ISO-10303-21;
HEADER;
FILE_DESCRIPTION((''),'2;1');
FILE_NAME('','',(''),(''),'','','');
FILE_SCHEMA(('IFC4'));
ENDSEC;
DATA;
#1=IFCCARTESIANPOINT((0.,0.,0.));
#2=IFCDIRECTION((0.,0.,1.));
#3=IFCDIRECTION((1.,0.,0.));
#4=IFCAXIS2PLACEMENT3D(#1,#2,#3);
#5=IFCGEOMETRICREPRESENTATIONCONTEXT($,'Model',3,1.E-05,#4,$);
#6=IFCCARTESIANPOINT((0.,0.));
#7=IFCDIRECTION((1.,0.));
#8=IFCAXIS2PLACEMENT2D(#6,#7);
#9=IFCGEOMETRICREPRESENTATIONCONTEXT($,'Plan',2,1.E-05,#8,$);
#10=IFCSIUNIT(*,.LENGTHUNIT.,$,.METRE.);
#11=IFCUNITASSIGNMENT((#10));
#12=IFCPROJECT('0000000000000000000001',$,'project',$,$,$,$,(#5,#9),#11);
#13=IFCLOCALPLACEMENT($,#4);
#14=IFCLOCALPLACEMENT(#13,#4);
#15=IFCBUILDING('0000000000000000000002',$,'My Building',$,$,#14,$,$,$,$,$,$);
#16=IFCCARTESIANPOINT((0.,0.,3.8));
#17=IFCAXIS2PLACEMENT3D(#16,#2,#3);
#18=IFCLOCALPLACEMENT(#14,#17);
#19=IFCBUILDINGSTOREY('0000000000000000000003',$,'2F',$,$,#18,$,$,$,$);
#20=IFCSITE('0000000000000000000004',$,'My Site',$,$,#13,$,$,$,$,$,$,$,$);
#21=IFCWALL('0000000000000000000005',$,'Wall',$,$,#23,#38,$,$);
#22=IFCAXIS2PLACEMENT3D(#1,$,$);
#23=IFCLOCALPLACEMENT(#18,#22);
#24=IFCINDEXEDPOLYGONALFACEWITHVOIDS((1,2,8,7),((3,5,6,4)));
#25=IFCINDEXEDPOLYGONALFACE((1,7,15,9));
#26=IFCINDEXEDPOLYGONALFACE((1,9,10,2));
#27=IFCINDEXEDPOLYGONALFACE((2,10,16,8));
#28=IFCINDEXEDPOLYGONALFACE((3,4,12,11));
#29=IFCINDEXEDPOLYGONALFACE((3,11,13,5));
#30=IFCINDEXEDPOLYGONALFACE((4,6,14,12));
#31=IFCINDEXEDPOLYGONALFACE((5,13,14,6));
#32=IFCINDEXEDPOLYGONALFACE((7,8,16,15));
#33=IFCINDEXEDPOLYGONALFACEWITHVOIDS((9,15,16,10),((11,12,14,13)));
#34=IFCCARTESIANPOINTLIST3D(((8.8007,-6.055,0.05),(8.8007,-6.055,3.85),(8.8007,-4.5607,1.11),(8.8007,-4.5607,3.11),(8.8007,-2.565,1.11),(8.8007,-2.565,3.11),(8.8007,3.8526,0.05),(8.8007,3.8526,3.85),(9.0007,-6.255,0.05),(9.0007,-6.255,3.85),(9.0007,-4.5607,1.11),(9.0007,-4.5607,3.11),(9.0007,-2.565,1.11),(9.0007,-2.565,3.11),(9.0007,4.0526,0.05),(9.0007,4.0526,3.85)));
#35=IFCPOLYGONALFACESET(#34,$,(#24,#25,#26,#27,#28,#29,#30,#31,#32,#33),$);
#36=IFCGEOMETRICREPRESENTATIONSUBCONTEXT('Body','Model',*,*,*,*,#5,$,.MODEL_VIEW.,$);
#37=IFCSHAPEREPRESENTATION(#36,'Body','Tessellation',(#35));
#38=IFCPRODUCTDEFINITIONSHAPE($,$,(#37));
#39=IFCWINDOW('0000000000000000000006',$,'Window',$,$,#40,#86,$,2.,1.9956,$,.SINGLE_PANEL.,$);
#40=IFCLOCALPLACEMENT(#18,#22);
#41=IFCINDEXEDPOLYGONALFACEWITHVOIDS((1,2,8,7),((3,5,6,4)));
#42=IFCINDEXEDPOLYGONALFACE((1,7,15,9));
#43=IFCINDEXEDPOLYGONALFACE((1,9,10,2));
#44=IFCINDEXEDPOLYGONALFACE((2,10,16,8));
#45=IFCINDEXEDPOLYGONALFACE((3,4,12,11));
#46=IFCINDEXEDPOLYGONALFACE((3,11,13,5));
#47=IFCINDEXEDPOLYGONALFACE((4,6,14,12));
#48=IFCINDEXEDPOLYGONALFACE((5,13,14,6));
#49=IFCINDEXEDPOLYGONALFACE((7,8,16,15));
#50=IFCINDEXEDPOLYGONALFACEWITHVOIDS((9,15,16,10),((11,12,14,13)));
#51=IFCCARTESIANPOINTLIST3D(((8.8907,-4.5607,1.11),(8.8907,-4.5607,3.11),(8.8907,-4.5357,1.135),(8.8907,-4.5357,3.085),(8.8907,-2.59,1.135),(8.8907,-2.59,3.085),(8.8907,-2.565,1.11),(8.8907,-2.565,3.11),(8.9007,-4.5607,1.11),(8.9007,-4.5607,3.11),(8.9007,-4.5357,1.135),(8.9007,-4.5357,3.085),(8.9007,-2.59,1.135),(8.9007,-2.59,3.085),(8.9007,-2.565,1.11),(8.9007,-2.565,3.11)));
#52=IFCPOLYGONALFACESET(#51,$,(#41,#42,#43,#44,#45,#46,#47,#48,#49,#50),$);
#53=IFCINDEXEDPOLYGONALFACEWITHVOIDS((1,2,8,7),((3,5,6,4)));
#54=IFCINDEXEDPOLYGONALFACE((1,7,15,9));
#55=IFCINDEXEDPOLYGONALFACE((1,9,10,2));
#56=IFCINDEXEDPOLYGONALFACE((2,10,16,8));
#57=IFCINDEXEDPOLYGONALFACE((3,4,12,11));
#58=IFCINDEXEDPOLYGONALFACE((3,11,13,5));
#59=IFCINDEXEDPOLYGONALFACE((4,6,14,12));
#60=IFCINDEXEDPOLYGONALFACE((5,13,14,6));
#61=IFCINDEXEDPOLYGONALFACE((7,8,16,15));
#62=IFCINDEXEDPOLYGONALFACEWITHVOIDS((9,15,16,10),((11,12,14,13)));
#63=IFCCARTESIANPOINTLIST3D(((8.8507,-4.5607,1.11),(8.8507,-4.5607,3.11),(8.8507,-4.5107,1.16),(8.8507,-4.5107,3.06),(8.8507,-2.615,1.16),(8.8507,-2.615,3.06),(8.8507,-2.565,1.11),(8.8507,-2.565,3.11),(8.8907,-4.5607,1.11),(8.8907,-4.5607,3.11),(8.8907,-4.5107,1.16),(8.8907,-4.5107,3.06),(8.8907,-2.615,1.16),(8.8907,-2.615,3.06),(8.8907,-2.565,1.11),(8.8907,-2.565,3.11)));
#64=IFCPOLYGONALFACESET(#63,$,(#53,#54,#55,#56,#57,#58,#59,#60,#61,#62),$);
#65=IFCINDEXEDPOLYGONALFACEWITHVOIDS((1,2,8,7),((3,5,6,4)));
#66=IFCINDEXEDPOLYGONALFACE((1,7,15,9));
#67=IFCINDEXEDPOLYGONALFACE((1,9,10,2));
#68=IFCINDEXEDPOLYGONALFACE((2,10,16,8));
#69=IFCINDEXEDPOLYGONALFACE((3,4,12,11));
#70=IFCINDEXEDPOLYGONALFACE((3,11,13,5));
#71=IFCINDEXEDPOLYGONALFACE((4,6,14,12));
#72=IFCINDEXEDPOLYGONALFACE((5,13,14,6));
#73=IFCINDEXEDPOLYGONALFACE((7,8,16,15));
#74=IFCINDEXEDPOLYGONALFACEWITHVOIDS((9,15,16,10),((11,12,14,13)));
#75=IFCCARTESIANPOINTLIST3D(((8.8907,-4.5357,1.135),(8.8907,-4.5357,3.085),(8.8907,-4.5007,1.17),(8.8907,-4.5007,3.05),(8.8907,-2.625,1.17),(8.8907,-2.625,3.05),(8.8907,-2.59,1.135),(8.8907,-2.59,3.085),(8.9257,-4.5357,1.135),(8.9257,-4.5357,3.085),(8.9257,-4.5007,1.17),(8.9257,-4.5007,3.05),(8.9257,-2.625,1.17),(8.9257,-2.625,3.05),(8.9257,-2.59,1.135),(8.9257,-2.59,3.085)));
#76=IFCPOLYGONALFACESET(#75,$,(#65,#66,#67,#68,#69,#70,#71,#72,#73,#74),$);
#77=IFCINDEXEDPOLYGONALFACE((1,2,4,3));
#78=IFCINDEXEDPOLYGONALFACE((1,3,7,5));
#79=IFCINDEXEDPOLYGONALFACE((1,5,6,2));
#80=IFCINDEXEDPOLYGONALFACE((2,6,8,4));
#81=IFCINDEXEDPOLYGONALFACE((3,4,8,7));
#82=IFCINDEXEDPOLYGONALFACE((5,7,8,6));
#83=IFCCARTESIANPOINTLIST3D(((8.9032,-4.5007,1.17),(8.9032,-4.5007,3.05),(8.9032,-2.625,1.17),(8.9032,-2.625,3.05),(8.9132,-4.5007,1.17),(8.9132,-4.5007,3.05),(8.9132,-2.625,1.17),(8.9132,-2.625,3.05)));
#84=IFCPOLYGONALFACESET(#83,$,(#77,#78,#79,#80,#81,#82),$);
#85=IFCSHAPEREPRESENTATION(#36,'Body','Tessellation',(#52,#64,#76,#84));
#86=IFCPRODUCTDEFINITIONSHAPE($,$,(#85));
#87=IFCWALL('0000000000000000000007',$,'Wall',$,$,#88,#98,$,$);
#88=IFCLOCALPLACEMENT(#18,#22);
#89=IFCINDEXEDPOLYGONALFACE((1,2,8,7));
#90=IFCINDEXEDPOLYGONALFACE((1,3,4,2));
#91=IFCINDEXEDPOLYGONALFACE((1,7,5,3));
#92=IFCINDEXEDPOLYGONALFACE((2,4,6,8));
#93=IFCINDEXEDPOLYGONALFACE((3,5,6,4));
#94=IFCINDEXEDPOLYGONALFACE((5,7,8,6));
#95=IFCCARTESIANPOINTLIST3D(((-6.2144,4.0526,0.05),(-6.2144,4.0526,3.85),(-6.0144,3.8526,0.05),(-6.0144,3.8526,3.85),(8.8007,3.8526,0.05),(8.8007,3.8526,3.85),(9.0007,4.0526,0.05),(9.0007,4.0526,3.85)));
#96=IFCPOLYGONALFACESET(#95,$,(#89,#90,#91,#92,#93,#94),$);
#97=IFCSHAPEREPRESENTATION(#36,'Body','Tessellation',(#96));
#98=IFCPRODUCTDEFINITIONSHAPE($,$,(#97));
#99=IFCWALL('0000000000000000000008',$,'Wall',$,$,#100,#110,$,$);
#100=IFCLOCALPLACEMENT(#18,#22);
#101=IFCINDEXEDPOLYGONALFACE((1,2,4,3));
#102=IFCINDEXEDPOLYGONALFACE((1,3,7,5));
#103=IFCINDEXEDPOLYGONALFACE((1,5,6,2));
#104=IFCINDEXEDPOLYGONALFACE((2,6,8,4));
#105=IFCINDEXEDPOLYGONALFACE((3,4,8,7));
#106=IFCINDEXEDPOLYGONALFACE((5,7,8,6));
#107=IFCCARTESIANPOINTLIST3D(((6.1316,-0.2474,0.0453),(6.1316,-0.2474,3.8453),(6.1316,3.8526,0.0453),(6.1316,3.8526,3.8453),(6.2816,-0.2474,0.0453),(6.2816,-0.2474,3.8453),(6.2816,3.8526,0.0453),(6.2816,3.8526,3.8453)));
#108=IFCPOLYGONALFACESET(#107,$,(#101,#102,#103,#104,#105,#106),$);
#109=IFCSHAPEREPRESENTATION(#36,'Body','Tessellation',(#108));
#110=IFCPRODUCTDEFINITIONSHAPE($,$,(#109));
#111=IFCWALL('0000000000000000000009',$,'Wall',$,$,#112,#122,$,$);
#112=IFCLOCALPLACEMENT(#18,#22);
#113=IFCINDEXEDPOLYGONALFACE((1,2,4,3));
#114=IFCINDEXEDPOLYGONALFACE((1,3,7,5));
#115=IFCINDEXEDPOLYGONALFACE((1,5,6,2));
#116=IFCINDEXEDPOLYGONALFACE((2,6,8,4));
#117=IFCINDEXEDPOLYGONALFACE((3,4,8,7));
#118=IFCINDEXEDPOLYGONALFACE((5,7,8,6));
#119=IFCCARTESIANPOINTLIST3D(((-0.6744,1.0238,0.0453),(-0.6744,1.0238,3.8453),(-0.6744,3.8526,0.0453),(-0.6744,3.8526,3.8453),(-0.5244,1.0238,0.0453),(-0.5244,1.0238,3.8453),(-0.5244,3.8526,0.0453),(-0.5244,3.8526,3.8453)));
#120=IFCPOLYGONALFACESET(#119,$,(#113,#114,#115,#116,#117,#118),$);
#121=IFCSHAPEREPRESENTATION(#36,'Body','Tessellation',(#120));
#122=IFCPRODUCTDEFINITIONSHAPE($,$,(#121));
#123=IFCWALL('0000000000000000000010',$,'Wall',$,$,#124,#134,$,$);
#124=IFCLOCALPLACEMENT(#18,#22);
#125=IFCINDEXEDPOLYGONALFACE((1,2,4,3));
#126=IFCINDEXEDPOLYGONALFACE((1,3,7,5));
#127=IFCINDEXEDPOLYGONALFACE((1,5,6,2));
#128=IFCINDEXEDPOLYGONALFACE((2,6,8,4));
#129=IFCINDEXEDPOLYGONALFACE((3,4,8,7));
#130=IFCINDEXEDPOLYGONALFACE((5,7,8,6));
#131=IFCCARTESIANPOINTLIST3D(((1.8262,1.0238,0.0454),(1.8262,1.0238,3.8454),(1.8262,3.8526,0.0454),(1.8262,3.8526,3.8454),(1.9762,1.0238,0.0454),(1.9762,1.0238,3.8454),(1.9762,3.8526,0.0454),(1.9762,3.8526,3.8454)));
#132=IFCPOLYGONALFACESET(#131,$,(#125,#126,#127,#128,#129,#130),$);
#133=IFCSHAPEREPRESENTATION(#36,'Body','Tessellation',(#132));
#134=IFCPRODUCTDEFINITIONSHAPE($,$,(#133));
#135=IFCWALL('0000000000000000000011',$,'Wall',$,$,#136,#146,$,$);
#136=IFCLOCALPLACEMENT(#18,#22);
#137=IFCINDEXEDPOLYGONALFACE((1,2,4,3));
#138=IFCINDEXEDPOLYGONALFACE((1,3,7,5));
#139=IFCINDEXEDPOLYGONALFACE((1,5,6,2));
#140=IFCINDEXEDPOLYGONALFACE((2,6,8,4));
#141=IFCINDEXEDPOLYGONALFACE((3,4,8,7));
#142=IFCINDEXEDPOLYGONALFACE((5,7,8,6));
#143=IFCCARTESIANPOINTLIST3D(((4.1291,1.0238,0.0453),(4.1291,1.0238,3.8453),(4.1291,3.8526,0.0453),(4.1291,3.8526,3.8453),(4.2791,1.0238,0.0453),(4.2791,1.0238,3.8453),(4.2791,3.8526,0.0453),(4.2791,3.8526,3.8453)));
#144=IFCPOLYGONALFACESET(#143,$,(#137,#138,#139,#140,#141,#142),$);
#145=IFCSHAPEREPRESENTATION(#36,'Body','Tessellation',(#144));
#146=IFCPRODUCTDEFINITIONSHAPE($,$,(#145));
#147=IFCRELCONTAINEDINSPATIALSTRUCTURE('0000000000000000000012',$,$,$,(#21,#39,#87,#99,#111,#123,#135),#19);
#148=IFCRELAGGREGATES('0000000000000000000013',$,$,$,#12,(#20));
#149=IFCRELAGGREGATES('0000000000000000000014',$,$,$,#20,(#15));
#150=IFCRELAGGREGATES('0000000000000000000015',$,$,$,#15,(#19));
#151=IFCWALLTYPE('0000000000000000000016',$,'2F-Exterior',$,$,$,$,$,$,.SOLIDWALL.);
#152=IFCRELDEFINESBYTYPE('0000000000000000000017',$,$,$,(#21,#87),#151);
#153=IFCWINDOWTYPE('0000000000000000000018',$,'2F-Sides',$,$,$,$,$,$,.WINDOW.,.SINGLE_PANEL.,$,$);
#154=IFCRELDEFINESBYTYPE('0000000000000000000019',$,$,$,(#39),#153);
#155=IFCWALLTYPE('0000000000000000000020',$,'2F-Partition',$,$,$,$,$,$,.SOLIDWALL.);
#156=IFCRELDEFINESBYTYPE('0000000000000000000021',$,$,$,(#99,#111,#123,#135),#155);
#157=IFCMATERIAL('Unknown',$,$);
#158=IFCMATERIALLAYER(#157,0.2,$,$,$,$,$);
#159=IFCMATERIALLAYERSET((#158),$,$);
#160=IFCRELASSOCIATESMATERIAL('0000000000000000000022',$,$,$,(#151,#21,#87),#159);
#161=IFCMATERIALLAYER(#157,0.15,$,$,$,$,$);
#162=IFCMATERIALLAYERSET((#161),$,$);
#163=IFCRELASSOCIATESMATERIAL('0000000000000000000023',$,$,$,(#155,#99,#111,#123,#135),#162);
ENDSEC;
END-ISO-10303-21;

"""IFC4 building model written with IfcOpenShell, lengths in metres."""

from ifc_helpers import new_model, entity, si_unit, frame, origin_with_axes, origin_2d_with_axis, place, context, subcontext, project, spatial, line, indexed_curve, outline, extrude, shape, source, transform, mapped, material, layer, layer_set, layer_usage, type_object, type_shapes, element, fill, save


model = new_model("IFC4")

# Units and contexts
model_context = context("Model", 3, precision=1e-05, world=origin_with_axes())
plan_context = context("Plan", 2, precision=1e-05, world=origin_2d_with_axis())
body_context_1 = subcontext(model_context, "Body", "Model", "MODEL_VIEW")
body_context_2 = subcontext(plan_context, "Body", "Plan", "PLAN_VIEW")
ifc_project = project(units=[si_unit("LENGTHUNIT", "METRE")], contexts=[model_context, plan_context])

# Site, building, storey
site_placement = place(None, origin_with_axes())
site = spatial("IfcSite", under=ifc_project, at=site_placement, Name="My Site")
building_placement = place(site_placement, origin_with_axes())
building = spatial("IfcBuilding", under=site, at=building_placement, Name="My Building")
storey_placement = place(building_placement, frame((0.0, 0.0, 3.8), z_axis=(0.0, 0.0, 1.0), x_axis=(1.0, 0.0, 0.0)))
storey = spatial("IfcBuildingStorey", under=building, at=storey_placement, Name="2F")

# Shared definitions
ifc_material = material(Name="Unknown")

# Wall, opening, window
ifc_layer_1 = layer(ifc_material, 0.2)
ifc_layer_set_1 = layer_set([ifc_layer_1])
ifc_layer_usage_1 = layer_usage(ifc_layer_set_1, "AXIS2", "POSITIVE", 0.0)
wall_type_1 = type_object("IfcWallType", Name="2F-Exterior", PredefinedType="SOLIDWALL", material=ifc_layer_set_1)
wall_1_placement = place(storey_placement, frame((9.0007, -6.255, 0.05), z_axis=(0.0, 0.0, 1.0), x_axis=(0.0, 1.0, 0.0)))
wall_1 = element("IfcWall", 1, at=wall_1_placement, inside=storey, type_object=wall_type_1, material=ifc_layer_usage_1, Name="Wall", context=body_context_1, shape_type="SweptSolid", body=[
    extrude(outline(indexed_curve([(0.0, 0.0), (0.2, 0.2), (10.1077, 0.2), (10.3077, 0.0)], segments=[line(1, 2, 3, 4, 1)])), origin_with_axes(), (0.0, 0.0, 1.0), 3.8),
])
shared_shape_1 = source(origin_with_axes(), body_context_1, "Body", "SweptSolid", [
    extrude(outline(indexed_curve([(0.0, 0.0), (1.9956, 0.0), (1.9956, 2.0), (0.0, 2.0)], segments=[line(1, 2, 3, 4, 1)])), frame((0.0, -0.6, 0.0), z_axis=(0.0, -1.0, 0.0), x_axis=(1.0, 0.0, 0.0)), (0.0, 0.0, -1.0), 1.2),
])
opening_1_placement = place(wall_1_placement, frame((3.69, 0.2, 1.06), z_axis=(0.0, 0.0, 1.0), x_axis=(-1.0, 0.0, 0.0)))
opening_1 = element("IfcOpeningElement", 2, at=opening_1_placement, cuts=wall_1, PredefinedType="OPENING", context=body_context_1, shape_type="MappedRepresentation", body=[
    mapped(shared_shape_1, transform((0.0, 0.0, 0.0), x_axis=(1.0, 0.0, 0.0), y_axis=(0.0, 1.0, 0.0), z_axis=(0.0, 0.0, 1.0), scale=1.0)),
])
window_type_1 = type_object("IfcWindowType", Name="2F-Sides", PartitioningType="SINGLE_PANEL", PredefinedType="WINDOW")
shared_shape_2 = source(origin_with_axes(), body_context_1, "Body", "SweptSolid", [
    extrude(outline(indexed_curve([(0.0, 0.0), (1.9956, 0.0), (1.9956, 2.0), (0.0, 2.0)], segments=[line(1, 2, 3, 4, 1)]), holes=[indexed_curve([(0.025, 0.025), (1.9706, 0.025), (1.9706, 1.975), (0.025, 1.975)], segments=[line(1, 2, 3, 4, 1)])]), frame((0.0, 0.09, 0.0), z_axis=(0.0, -1.0, 0.0), x_axis=(1.0, 0.0, 0.0)), (0.0, 0.0, -1.0), 0.01),
    extrude(outline(indexed_curve([(0.0, 0.0), (1.9956, 0.0), (1.9956, 2.0), (0.0, 2.0)], segments=[line(1, 2, 3, 4, 1)]), holes=[indexed_curve([(0.05, 0.05), (1.9456, 0.05), (1.9456, 1.95), (0.05, 1.95)], segments=[line(1, 2, 3, 4, 1)])]), frame((0.0, 0.05, 0.0), z_axis=(0.0, -1.0, 0.0), x_axis=(1.0, 0.0, 0.0)), (0.0, 0.0, -1.0), 0.04),
    extrude(outline(indexed_curve([(0.0, 0.0), (1.9456, 0.0), (1.9456, 1.95), (0.0, 1.95)], segments=[line(1, 2, 3, 4, 1)]), holes=[indexed_curve([(0.035, 0.035), (1.9106, 0.035), (1.9106, 1.915), (0.035, 1.915)], segments=[line(1, 2, 3, 4, 1)])]), frame((0.025, 0.09, 0.025), z_axis=(0.0, -1.0, 0.0), x_axis=(1.0, 0.0, 0.0)), (0.0, 0.0, -1.0), 0.035),
    extrude(outline(indexed_curve([(0.035, 0.035), (1.9106, 0.035), (1.9106, 1.915), (0.035, 1.915)], segments=[line(1, 2, 3, 4, 1)])), frame((0.025, 0.1025, 0.025), z_axis=(0.0, -1.0, 0.0), x_axis=(1.0, 0.0, 0.0)), (0.0, 0.0, -1.0), 0.01),
])
shared_shape_3 = source(origin_with_axes(), body_context_2, "Body", "Curve2D", [
    entity("IfcIndexedPolyCurve", entity("IfcCartesianPointList2D", [[0.05, 0.05], [1.9456, 0.05]])),
    entity("IfcIndexedPolyCurve", entity("IfcCartesianPointList2D", [[0.0, 0.1], [0.025, 0.1], [0.025, 0.09], [0.05, 0.09], [0.05, 0.05], [0.0, 0.05]]), [entity("IfcLineIndex", [1, 2, 3, 4, 5, 6, 1])]),
    entity("IfcIndexedPolyCurve", entity("IfcCartesianPointList2D", [[1.9956, 0.1], [1.9706, 0.1], [1.9706, 0.09], [1.9456, 0.09], [1.9456, 0.05], [1.9956, 0.05]]), [entity("IfcLineIndex", [1, 2, 3, 4, 5, 6, 1])]),
    entity("IfcIndexedPolyCurve", entity("IfcCartesianPointList2D", [[0.025, 0.09], [0.06, 0.09], [0.06, 0.125], [0.025, 0.125]]), [entity("IfcLineIndex", [1, 2, 3, 4, 1])]),
    entity("IfcIndexedPolyCurve", entity("IfcCartesianPointList2D", [[1.9706, 0.09], [1.9356, 0.09], [1.9356, 0.125], [1.9706, 0.125]]), [entity("IfcLineIndex", [1, 2, 3, 4, 1])]),
    entity("IfcIndexedPolyCurve", entity("IfcCartesianPointList2D", [[0.06, 0.09], [1.9356, 0.09]])),
    entity("IfcIndexedPolyCurve", entity("IfcCartesianPointList2D", [[0.06, 0.125], [1.9356, 0.125]])),
    entity("IfcIndexedPolyCurve", entity("IfcCartesianPointList2D", [[0.06, 0.1075], [1.9356, 0.1075]])),
])
type_shapes(window_type_1, [shared_shape_2, shared_shape_3])
window_placement = place(opening_1_placement, origin_with_axes())
window = element("IfcWindow", 3, at=window_placement, inside=storey, type_object=window_type_1, Name="Window", OverallHeight=2.0, OverallWidth=1.9956, PartitioningType="SINGLE_PANEL", shapes=[
    shape(body_context_1, "Body", "MappedRepresentation", [mapped(shared_shape_2, transform((0.0, 0.0, 0.0), x_axis=(1.0, 0.0, 0.0), y_axis=(0.0, 1.0, 0.0), z_axis=(0.0, 0.0, 1.0), scale=1.0))]),
    shape(body_context_2, "Body", "MappedRepresentation", [mapped(shared_shape_3, transform((0.0, 0.0, 0.0), x_axis=(1.0, 0.0, 0.0), y_axis=(0.0, 1.0, 0.0), z_axis=(0.0, 0.0, 1.0), scale=1.0))]),
])
fill(opening_1, window)

# Walls
ifc_layer_usage_2 = layer_usage(ifc_layer_set_1, "AXIS2", "POSITIVE", 0.0)
wall_2_placement = place(storey_placement, frame((9.0007, 4.0526, 0.05), z_axis=(0.0, 0.0, 1.0), x_axis=(-1.0, 0.0, 0.0)))
element("IfcWall", 4, at=wall_2_placement, inside=storey, type_object=wall_type_1, material=ifc_layer_usage_2, Name="Wall", context=body_context_1, shape_type="SweptSolid", body=[
    extrude(outline(indexed_curve([(0.0, 0.0), (0.2, 0.2), (15.0151, 0.2), (15.2151, 0.0)], segments=[line(1, 2, 3, 4, 1)])), origin_with_axes(), (0.0, 0.0, 1.0), 3.8),
])
ifc_layer_2 = layer(ifc_material, 0.15)
ifc_layer_set_2 = layer_set([ifc_layer_2])
ifc_layer_usage_3 = layer_usage(ifc_layer_set_2, "AXIS2", "POSITIVE", 0.0)
wall_type_2 = type_object("IfcWallType", Name="2F-Partition", PredefinedType="SOLIDWALL", material=ifc_layer_set_2)
wall_3_placement = place(storey_placement, frame((6.2816, -0.2474, 0.0453), z_axis=(0.0, 0.0, 1.0), x_axis=(0.0, 1.0, 0.0)))
element("IfcWall", 5, at=wall_3_placement, inside=storey, type_object=wall_type_2, material=ifc_layer_usage_3, Name="Wall", context=body_context_1, shape_type="SweptSolid", body=[
    extrude(outline(indexed_curve([(0.0, 0.0), (0.0, 0.15), (4.1, 0.15), (4.1, 0.0)], segments=[line(1, 2, 3, 4, 1)])), origin_with_axes(), (0.0, 0.0, 1.0), 3.8),
])

# Walls
ifc_layer_usage_4 = layer_usage(ifc_layer_set_2, "AXIS2", "POSITIVE", 0.0)
wall_4_placement = place(storey_placement, frame((-0.5244, 1.0238, 0.0453), z_axis=(0.0, 0.0, 1.0), x_axis=(0.0, 1.0, 0.0)))
element("IfcWall", 6, at=wall_4_placement, inside=storey, type_object=wall_type_2, material=ifc_layer_usage_4, Name="Wall", context=body_context_1, shape_type="SweptSolid", body=[
    extrude(outline(indexed_curve([(0.0, 0.0), (0.0, 0.15), (2.8288, 0.15), (2.8288, 0.0)], segments=[line(1, 2, 3, 4, 1)])), origin_with_axes(), (0.0, 0.0, 1.0), 3.8),
])
ifc_layer_usage_5 = layer_usage(ifc_layer_set_2, "AXIS2", "POSITIVE", 0.0)
wall_5_placement = place(storey_placement, frame((1.9762, 1.0238, 0.0454), z_axis=(0.0, 0.0, 1.0), x_axis=(0.0, 1.0, 0.0)))
element("IfcWall", 7, at=wall_5_placement, inside=storey, type_object=wall_type_2, material=ifc_layer_usage_5, Name="Wall", context=body_context_1, shape_type="SweptSolid", body=[
    extrude(outline(indexed_curve([(0.0, 0.0), (0.0, 0.15), (2.8288, 0.15), (2.8288, 0.0)], segments=[line(1, 2, 3, 4, 1)])), origin_with_axes(), (0.0, 0.0, 1.0), 3.8),
])
ifc_layer_usage_6 = layer_usage(ifc_layer_set_2, "AXIS2", "POSITIVE", 0.0)
wall_6_placement = place(storey_placement, frame((4.2791, 1.0238, 0.0453), z_axis=(0.0, 0.0, 1.0), x_axis=(0.0, 1.0, 0.0)))
element("IfcWall", 8, at=wall_6_placement, inside=storey, type_object=wall_type_2, material=ifc_layer_usage_6, Name="Wall", context=body_context_1, shape_type="SweptSolid", body=[
    extrude(outline(indexed_curve([(0.0, 0.0), (0.0, 0.15), (2.8288, 0.15), (2.8288, 0.0)], segments=[line(1, 2, 3, 4, 1)])), origin_with_axes(), (0.0, 0.0, 1.0), 3.8),
])

save(model, "model.ifc")
